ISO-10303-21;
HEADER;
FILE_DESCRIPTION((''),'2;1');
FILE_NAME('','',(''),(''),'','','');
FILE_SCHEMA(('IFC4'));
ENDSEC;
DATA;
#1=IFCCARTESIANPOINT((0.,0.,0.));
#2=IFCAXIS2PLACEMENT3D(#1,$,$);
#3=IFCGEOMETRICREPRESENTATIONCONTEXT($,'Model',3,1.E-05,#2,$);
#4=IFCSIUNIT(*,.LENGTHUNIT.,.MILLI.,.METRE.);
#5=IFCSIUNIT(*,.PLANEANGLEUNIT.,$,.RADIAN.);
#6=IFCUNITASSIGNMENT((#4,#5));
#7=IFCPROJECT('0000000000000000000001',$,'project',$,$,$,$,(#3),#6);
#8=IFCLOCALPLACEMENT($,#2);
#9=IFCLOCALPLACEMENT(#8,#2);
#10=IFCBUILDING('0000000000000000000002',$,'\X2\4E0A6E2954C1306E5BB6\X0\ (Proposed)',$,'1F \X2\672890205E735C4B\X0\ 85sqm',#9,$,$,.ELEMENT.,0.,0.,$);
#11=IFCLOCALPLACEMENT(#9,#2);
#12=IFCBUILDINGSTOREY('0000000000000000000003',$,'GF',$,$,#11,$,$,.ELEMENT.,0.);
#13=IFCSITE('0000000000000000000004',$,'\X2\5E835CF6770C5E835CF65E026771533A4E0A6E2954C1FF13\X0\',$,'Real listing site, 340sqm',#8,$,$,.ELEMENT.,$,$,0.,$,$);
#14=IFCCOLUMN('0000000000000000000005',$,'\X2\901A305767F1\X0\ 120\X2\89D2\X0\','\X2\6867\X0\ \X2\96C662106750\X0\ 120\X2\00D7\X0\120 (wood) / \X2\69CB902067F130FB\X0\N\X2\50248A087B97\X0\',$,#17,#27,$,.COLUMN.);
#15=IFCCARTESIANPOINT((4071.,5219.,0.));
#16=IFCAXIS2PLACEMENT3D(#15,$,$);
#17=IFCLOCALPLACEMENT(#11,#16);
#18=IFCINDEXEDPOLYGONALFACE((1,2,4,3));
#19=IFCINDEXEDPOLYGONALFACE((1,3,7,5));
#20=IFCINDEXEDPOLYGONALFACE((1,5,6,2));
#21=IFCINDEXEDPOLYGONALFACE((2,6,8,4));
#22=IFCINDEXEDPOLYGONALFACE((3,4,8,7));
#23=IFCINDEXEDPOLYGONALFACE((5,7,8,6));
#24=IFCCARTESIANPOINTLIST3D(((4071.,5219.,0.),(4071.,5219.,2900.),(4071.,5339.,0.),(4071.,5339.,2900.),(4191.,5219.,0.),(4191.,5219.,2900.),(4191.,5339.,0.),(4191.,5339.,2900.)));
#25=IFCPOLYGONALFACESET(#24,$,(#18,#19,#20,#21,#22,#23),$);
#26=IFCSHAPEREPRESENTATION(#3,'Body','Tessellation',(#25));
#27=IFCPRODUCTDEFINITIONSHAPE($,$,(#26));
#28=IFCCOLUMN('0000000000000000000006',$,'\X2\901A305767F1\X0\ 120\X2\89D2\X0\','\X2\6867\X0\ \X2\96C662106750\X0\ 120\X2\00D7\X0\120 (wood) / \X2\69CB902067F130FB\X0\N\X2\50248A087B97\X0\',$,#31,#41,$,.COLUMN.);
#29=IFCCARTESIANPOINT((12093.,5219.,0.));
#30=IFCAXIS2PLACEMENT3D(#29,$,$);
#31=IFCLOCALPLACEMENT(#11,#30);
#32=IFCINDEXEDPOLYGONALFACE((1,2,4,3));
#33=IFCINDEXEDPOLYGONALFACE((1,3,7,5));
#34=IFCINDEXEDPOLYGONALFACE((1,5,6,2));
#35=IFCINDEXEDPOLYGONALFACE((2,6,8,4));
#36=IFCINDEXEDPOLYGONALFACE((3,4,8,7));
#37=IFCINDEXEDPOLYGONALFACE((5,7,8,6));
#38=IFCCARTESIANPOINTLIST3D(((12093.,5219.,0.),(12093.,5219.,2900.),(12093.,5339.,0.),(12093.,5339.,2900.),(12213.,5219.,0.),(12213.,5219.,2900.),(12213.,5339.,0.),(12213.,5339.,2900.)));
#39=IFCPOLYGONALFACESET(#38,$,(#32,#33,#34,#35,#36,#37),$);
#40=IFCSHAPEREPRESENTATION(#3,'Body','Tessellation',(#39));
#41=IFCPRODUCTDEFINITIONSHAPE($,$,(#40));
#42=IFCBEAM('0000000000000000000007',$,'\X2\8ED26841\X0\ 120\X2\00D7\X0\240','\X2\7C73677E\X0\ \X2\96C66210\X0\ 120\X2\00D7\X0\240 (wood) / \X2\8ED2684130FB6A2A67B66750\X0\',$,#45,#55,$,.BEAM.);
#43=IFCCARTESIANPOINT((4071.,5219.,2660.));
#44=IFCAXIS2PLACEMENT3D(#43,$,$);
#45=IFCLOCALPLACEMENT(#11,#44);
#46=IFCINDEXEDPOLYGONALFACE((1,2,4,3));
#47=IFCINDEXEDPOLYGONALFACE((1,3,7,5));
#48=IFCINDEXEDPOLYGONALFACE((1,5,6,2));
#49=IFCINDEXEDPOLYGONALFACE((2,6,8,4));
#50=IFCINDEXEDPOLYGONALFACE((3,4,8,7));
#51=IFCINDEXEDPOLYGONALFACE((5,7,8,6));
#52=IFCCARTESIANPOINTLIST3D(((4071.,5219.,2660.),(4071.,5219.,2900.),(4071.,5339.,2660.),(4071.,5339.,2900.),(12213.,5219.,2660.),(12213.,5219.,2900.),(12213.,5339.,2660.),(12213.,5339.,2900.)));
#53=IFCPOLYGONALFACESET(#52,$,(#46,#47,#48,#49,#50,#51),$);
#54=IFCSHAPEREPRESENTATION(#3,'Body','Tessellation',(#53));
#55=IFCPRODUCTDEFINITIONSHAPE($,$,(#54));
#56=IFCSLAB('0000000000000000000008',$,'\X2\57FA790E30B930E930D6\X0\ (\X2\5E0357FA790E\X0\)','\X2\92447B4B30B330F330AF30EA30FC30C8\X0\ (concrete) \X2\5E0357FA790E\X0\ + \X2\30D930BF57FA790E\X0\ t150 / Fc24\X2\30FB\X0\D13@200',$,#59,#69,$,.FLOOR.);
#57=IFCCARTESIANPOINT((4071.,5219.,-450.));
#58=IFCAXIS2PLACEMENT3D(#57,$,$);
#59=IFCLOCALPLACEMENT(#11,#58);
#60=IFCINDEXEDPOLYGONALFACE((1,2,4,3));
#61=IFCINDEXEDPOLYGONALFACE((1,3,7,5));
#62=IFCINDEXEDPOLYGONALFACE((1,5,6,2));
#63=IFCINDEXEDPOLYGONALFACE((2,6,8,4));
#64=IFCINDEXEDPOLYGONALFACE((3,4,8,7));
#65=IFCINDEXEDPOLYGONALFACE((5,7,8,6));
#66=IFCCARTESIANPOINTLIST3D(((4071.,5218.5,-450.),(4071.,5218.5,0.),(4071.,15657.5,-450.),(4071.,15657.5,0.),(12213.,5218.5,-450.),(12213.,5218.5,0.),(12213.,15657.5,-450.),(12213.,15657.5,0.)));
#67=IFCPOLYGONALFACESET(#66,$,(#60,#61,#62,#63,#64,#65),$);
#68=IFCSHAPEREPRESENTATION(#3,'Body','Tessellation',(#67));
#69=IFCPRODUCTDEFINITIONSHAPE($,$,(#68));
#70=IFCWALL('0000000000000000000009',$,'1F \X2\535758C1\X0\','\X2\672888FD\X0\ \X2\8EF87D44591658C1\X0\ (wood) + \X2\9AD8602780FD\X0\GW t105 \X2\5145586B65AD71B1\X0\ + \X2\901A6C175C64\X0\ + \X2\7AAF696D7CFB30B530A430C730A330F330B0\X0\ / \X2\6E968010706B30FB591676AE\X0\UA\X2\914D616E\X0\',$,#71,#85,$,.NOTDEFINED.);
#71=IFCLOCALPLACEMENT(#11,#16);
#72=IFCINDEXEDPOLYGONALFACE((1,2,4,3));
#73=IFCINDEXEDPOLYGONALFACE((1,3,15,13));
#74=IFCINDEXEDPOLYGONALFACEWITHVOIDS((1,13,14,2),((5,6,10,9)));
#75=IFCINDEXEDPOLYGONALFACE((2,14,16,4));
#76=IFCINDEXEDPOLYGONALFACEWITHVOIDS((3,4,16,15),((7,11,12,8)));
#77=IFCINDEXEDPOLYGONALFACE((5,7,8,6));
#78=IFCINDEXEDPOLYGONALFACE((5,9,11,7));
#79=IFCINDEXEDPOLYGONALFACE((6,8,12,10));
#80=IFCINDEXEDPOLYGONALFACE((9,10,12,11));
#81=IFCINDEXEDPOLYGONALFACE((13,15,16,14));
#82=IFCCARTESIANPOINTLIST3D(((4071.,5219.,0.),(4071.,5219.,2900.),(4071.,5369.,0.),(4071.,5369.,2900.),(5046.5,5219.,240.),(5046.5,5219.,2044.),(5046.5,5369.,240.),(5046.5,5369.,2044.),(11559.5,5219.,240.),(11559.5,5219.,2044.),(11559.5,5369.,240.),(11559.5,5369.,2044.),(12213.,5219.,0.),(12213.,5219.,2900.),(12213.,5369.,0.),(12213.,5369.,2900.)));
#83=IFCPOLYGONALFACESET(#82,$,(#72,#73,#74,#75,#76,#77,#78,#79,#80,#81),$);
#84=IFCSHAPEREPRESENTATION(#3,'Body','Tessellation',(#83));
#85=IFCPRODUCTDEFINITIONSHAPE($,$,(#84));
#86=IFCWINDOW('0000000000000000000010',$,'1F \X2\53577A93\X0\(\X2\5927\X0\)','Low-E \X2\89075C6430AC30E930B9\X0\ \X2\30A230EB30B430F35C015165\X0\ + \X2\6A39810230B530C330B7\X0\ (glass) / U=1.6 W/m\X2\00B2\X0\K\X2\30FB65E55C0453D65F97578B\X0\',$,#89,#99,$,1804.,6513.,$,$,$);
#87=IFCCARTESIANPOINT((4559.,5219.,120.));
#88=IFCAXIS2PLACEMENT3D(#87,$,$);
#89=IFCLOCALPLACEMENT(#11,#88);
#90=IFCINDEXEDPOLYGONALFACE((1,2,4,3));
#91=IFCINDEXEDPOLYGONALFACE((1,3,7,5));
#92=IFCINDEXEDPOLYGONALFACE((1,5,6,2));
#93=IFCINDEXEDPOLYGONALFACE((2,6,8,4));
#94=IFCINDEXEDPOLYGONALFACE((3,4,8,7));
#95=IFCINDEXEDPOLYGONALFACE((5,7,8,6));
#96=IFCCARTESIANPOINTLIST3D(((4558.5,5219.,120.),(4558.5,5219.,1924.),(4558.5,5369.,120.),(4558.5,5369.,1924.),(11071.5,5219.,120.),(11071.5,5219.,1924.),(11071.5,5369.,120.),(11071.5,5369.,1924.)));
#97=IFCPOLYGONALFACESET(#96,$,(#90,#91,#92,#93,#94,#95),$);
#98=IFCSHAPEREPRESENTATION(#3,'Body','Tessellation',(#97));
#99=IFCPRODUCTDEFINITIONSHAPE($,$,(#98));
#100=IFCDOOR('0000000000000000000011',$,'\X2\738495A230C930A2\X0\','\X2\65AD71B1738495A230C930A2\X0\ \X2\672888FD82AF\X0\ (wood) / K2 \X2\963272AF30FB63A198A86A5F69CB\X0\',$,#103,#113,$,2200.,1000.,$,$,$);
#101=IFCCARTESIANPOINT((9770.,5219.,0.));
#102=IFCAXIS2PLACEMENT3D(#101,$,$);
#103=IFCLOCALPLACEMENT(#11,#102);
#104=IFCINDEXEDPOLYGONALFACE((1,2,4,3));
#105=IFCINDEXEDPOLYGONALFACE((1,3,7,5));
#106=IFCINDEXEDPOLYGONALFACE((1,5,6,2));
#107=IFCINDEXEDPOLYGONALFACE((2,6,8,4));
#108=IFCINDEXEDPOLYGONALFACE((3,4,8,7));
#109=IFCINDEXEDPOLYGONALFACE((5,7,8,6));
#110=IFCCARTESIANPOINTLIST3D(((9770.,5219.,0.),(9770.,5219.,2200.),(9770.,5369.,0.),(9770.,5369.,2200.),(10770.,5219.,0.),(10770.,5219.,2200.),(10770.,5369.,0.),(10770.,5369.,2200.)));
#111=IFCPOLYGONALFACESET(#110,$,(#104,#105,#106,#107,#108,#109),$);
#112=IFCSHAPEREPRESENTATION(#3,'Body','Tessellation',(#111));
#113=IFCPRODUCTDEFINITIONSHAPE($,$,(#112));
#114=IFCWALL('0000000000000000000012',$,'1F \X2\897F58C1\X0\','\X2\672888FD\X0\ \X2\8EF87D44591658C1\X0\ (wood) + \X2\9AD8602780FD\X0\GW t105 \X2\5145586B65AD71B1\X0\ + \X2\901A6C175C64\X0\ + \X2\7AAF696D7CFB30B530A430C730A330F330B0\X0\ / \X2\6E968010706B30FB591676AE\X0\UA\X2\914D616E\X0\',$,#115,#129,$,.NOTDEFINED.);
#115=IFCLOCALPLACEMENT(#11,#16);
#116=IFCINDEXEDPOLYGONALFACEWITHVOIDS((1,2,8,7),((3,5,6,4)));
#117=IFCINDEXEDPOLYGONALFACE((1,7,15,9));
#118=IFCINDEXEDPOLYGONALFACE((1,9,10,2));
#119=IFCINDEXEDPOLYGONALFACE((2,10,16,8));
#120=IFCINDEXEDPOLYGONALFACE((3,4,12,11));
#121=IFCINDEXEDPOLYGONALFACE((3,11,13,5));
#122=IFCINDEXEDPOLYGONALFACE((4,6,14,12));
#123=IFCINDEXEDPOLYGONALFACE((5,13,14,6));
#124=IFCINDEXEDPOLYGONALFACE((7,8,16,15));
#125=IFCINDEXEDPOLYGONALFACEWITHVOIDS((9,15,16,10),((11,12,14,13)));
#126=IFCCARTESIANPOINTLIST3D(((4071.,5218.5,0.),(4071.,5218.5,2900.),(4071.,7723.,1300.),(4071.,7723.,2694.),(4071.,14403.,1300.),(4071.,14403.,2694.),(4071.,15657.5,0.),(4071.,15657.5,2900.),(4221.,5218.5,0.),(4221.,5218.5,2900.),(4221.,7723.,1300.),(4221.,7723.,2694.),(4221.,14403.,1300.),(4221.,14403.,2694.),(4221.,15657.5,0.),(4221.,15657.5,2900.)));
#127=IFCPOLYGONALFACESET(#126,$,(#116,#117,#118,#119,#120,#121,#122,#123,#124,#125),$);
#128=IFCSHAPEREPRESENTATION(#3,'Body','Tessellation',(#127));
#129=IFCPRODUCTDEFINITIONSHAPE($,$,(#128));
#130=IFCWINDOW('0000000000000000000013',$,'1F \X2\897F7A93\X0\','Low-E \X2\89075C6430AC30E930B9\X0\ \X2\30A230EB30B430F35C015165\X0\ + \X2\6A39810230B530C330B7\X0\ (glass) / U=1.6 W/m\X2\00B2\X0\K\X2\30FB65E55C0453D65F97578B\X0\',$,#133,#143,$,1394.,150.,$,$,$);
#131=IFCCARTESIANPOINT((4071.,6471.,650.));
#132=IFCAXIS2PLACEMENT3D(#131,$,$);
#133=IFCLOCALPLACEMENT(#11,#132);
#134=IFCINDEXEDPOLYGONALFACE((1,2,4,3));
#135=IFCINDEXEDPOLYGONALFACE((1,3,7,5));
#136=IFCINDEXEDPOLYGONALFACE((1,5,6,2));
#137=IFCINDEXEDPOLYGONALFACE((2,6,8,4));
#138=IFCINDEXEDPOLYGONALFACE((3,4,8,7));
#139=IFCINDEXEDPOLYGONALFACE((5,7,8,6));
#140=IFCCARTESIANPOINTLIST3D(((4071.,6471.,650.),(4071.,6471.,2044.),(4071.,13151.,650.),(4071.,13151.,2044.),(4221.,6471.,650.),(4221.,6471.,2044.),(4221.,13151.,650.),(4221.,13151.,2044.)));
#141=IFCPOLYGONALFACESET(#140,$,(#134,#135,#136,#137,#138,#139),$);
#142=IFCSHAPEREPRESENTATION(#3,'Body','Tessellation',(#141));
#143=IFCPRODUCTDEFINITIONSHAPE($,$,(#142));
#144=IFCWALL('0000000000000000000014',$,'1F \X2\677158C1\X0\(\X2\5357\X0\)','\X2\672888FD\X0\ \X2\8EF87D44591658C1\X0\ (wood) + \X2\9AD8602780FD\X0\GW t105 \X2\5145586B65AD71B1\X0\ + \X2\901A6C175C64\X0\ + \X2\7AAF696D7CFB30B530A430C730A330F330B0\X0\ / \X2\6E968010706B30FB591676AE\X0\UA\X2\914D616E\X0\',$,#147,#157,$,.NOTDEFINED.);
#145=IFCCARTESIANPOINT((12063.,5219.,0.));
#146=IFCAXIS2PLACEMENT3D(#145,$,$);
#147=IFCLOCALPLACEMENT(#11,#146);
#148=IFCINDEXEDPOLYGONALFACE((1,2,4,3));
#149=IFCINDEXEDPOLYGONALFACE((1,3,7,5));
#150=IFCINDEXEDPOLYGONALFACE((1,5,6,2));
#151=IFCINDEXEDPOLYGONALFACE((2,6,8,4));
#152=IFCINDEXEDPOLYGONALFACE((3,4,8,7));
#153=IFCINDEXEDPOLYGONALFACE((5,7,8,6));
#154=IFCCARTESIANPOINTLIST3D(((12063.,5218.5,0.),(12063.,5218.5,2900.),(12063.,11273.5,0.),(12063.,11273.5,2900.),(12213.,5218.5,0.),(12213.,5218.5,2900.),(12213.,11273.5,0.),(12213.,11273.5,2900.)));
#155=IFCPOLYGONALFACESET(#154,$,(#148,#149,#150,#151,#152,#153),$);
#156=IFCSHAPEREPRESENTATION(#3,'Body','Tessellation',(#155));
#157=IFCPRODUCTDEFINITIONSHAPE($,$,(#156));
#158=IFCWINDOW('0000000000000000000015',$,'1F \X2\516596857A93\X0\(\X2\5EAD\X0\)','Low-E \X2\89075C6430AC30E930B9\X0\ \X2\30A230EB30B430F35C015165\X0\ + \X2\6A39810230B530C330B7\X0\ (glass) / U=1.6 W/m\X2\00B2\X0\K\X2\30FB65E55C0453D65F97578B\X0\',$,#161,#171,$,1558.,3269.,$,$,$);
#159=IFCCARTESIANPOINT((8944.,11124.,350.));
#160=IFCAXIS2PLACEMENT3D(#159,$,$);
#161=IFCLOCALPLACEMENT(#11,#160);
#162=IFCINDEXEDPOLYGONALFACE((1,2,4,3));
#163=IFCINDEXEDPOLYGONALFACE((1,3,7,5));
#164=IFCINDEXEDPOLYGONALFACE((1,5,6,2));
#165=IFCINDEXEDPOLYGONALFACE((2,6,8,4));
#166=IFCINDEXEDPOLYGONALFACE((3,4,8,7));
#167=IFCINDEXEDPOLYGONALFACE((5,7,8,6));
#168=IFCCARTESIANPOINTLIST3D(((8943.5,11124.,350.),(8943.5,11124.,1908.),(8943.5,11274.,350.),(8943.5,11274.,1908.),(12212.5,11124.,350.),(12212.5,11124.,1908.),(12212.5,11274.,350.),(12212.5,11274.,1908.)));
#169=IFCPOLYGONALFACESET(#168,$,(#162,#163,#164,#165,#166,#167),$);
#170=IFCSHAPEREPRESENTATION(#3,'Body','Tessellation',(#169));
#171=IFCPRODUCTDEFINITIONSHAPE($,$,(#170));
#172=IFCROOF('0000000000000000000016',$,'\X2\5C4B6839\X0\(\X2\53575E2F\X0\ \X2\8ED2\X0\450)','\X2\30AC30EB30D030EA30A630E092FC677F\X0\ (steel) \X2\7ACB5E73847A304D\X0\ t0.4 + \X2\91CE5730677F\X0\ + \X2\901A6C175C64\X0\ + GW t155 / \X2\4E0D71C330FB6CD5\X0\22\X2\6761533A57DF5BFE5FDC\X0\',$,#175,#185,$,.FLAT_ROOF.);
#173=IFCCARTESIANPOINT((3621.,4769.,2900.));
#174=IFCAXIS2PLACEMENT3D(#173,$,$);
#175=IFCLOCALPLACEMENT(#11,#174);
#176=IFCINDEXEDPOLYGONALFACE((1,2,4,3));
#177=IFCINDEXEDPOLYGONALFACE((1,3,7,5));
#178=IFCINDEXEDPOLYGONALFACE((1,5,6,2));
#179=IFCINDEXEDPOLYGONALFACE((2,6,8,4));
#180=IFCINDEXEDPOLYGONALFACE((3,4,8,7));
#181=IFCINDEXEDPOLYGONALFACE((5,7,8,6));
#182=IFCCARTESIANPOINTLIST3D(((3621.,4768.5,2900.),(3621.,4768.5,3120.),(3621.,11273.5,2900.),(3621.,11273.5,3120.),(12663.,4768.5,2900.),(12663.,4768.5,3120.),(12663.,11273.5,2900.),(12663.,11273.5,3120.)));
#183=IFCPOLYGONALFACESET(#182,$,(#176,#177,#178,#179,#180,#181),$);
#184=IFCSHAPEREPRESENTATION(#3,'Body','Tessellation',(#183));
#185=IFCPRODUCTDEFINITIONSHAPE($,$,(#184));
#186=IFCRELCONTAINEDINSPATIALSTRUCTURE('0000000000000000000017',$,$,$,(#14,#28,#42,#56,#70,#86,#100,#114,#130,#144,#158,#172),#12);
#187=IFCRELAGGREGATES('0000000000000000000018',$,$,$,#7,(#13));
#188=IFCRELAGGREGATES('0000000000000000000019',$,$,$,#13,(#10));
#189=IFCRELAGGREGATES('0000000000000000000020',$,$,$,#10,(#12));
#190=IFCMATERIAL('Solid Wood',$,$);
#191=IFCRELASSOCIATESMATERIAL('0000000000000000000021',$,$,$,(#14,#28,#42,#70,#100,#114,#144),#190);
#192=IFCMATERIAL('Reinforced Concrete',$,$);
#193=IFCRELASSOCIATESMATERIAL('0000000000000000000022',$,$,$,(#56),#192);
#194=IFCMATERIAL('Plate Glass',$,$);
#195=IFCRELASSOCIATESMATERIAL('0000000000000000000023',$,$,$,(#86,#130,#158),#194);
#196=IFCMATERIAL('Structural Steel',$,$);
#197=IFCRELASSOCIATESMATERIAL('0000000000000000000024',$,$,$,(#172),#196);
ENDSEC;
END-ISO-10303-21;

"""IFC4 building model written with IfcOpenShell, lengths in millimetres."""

from ifc_helpers import new_model, si_unit, frame, frame_2d, origin, place, context, project, spatial, rectangle, extrude, material, element, fill, save


model = new_model("IFC4")

# Units and contexts
model_context = context("Model", 3, precision=1e-05, world=origin())
ifc_project = project(units=[si_unit("LENGTHUNIT", "METRE", prefix="MILLI"), si_unit("PLANEANGLEUNIT", "RADIAN")], contexts=[model_context])

# Site, building, storey
site_placement = place(None, origin())
site = spatial("IfcSite", under=ifc_project, at=site_placement, Name="広島県広島市東区上温品３", ObjectType="Real listing site, 340sqm", CompositionType="ELEMENT", RefElevation=0.0)
building_placement = place(site_placement, origin())
building = spatial("IfcBuilding", under=site, at=building_placement, Name="上温品の家 (Proposed)", ObjectType="1F 木造平屋 85sqm", CompositionType="ELEMENT", ElevationOfRefHeight=0.0, ElevationOfTerrain=0.0)
storey_placement = place(building_placement, origin())
storey = spatial("IfcBuildingStorey", under=building, at=storey_placement, Name="GF", CompositionType="ELEMENT", Elevation=0.0)

# Columns
ifc_material_1 = material(Name="Solid Wood")
column_1_placement = place(storey_placement, frame((4071.0, 5219.0, 0.0)))
element("IfcColumn", 1, at=column_1_placement, inside=storey, material=ifc_material_1, Name="通し柱 120角", Description="桧 集成材 120×120 (wood) / 構造柱・N値計算", PredefinedType="COLUMN", context=model_context, shape_type="SweptSolid", body=[
    extrude(rectangle(XDim=120.0, YDim=120.0, at=frame_2d((60.0, 60.0))), frame((4071.0, 5219.0, 0.0)), (0.0, 0.0, 1.0), 2900.0),
])
column_2_placement = place(storey_placement, frame((12093.0, 5219.0, 0.0)))
element("IfcColumn", 2, at=column_2_placement, inside=storey, material=ifc_material_1, Name="通し柱 120角", Description="桧 集成材 120×120 (wood) / 構造柱・N値計算", PredefinedType="COLUMN", context=model_context, shape_type="SweptSolid", body=[
    extrude(rectangle(XDim=120.0, YDim=120.0, at=frame_2d((60.0, 60.0))), frame((12093.0, 5219.0, 0.0)), (0.0, 0.0, 1.0), 2900.0),
])

# Beam
beam_1_placement = place(storey_placement, frame((4071.0, 5219.0, 2660.0)))
element("IfcBeam", 3, at=beam_1_placement, inside=storey, material=ifc_material_1, Name="軒桁 120×240", Description="米松 集成 120×240 (wood) / 軒桁・横架材", PredefinedType="BEAM", context=model_context, shape_type="SweptSolid", body=[
    extrude(rectangle(XDim=8142.0, YDim=120.0, at=frame_2d((4071.0, 60.0))), frame((4071.0, 5219.0, 2660.0)), (0.0, 0.0, 1.0), 240.0),
])

# Slab
ifc_material_2 = material(Name="Reinforced Concrete")
slab_1_placement = place(storey_placement, frame((4071.0, 5219.0, -450.0)))
element("IfcSlab", 4, at=slab_1_placement, inside=storey, material=ifc_material_2, Name="基礎スラブ (布基礎)", Description="鉄筋コンクリート (concrete) 布基礎 + ベタ基礎 t150 / Fc24・D13@200", PredefinedType="FLOOR", context=model_context, shape_type="SweptSolid", body=[
    extrude(rectangle(XDim=8142.0, YDim=10439.0, at=frame_2d((4071.0, 5219.0))), frame((4071.0, 5219.0, -450.0)), (0.0, 0.0, 1.0), 450.0),
])

# Wall, openings, window, door
wall_1_placement = place(storey_placement, frame((4071.0, 5219.0, 0.0)))
wall_1 = element("IfcWall", 5, at=wall_1_placement, inside=storey, material=ifc_material_1, Name="1F 南壁", Description="木製 軸組外壁 (wood) + 高性能GW t105 充填断熱 + 通気層 + 窯業系サイディング / 準耐火・外皮UA配慮", PredefinedType="NOTDEFINED", context=model_context, shape_type="SweptSolid", body=[
    extrude(rectangle(XDim=8142.0, YDim=150.0, at=frame_2d((4071.0, 75.0))), frame((4071.0, 5219.0, 0.0)), (0.0, 0.0, 1.0), 2900.0),
])
opening_1_placement = place(storey_placement, frame((4559.0, 5219.0, 120.0)))
opening_1 = element("IfcOpeningElement", 6, at=opening_1_placement, cuts=wall_1, PredefinedType="NOTDEFINED", context=model_context, shape_type="SweptSolid", body=[
    extrude(rectangle(XDim=6513.0, YDim=150.0, at=frame_2d((3256.0, 75.0))), frame((4559.0, 5219.0, 120.0)), (0.0, 0.0, 1.0), 1804.0),
])
opening_2_placement = place(storey_placement, frame((9770.0, 5219.0, 0.0)))
opening_2 = element("IfcOpeningElement", 7, at=opening_2_placement, cuts=wall_1, PredefinedType="NOTDEFINED", context=model_context, shape_type="SweptSolid", body=[
    extrude(rectangle(XDim=1000.0, YDim=150.0, at=frame_2d((500.0, 75.0))), frame((9770.0, 5219.0, 0.0)), (0.0, 0.0, 1.0), 2200.0),
])
ifc_material_3 = material(Name="Plate Glass")
window_1_placement = place(storey_placement, frame((4559.0, 5219.0, 120.0)))
window_1 = element("IfcWindow", 8, at=window_1_placement, inside=storey, material=ifc_material_3, Name="1F 南窓(大)", Description="Low-E 複層ガラス アルゴン封入 + 樹脂サッシ (glass) / U=1.6 W/m²K・日射取得型", OverallHeight=1804.0, OverallWidth=6513.0, context=model_context, shape_type="SweptSolid", body=[
    extrude(rectangle(XDim=6513.0, YDim=150.0, at=frame_2d((3256.0, 75.0))), frame((4559.0, 5219.0, 120.0)), (0.0, 0.0, 1.0), 1804.0),
])
fill(opening_1, window_1)
door_1_placement = place(storey_placement, frame((9770.0, 5219.0, 0.0)))
door_1 = element("IfcDoor", 9, at=door_1_placement, inside=storey, material=ifc_material_1, Name="玄関ドア", Description="断熱玄関ドア 木製芯 (wood) / K2 防犯・採風機構", OverallHeight=2200.0, OverallWidth=1000.0, context=model_context, shape_type="SweptSolid", body=[
    extrude(rectangle(XDim=1000.0, YDim=150.0, at=frame_2d((500.0, 75.0))), frame((9770.0, 5219.0, 0.0)), (0.0, 0.0, 1.0), 2200.0),
])
fill(opening_2, door_1)

# Walls, openings, windows
wall_2_placement = place(storey_placement, frame((4071.0, 5219.0, 0.0)))
wall_2 = element("IfcWall", 10, at=wall_2_placement, inside=storey, material=ifc_material_1, Name="1F 西壁", Description="木製 軸組外壁 (wood) + 高性能GW t105 充填断熱 + 通気層 + 窯業系サイディング / 準耐火・外皮UA配慮", PredefinedType="NOTDEFINED", context=model_context, shape_type="SweptSolid", body=[
    extrude(rectangle(XDim=150.0, YDim=10439.0, at=frame_2d((75.0, 5219.0))), frame((4071.0, 5219.0, 0.0)), (0.0, 0.0, 1.0), 2900.0),
])
opening_3_placement = place(storey_placement, frame((4071.0, 6471.0, 650.0)))
opening_3 = element("IfcOpeningElement", 11, at=opening_3_placement, cuts=wall_2, PredefinedType="NOTDEFINED", context=model_context, shape_type="SweptSolid", body=[
    extrude(rectangle(XDim=150.0, YDim=6680.0, at=frame_2d((75.0, 3340.0))), frame((4071.0, 6471.0, 650.0)), (0.0, 0.0, 1.0), 1394.0),
])
window_2_placement = place(storey_placement, frame((4071.0, 6471.0, 650.0)))
window_2 = element("IfcWindow", 12, at=window_2_placement, inside=storey, material=ifc_material_3, Name="1F 西窓", Description="Low-E 複層ガラス アルゴン封入 + 樹脂サッシ (glass) / U=1.6 W/m²K・日射取得型", OverallHeight=1394.0, OverallWidth=150.0, context=model_context, shape_type="SweptSolid", body=[
    extrude(rectangle(XDim=150.0, YDim=6680.0, at=frame_2d((75.0, 3340.0))), frame((4071.0, 6471.0, 650.0)), (0.0, 0.0, 1.0), 1394.0),
])
fill(opening_3, window_2)
wall_3_placement = place(storey_placement, frame((12063.0, 5219.0, 0.0)))
wall_3 = element("IfcWall", 13, at=wall_3_placement, inside=storey, material=ifc_material_1, Name="1F 東壁(南)", Description="木製 軸組外壁 (wood) + 高性能GW t105 充填断熱 + 通気層 + 窯業系サイディング / 準耐火・外皮UA配慮", PredefinedType="NOTDEFINED", context=model_context, shape_type="SweptSolid", body=[
    extrude(rectangle(XDim=150.0, YDim=6055.0, at=frame_2d((75.0, 3027.0))), frame((12063.0, 5219.0, 0.0)), (0.0, 0.0, 1.0), 2900.0),
])
opening_4_placement = place(storey_placement, frame((8944.0, 11124.0, 350.0)))
opening_4 = element("IfcOpeningElement", 14, at=opening_4_placement, cuts=wall_3, PredefinedType="NOTDEFINED", context=model_context, shape_type="SweptSolid", body=[
    extrude(rectangle(XDim=3269.0, YDim=150.0, at=frame_2d((1634.0, 75.0))), frame((8944.0, 11124.0, 350.0)), (0.0, 0.0, 1.0), 1558.0),
])
window_3_placement = place(storey_placement, frame((8944.0, 11124.0, 350.0)))
window_3 = element("IfcWindow", 15, at=window_3_placement, inside=storey, material=ifc_material_3, Name="1F 入隅窓(庭)", Description="Low-E 複層ガラス アルゴン封入 + 樹脂サッシ (glass) / U=1.6 W/m²K・日射取得型", OverallHeight=1558.0, OverallWidth=3269.0, context=model_context, shape_type="SweptSolid", body=[
    extrude(rectangle(XDim=3269.0, YDim=150.0, at=frame_2d((1634.0, 75.0))), frame((8944.0, 11124.0, 350.0)), (0.0, 0.0, 1.0), 1558.0),
])
fill(opening_4, window_3)

# Roof
ifc_material_4 = material(Name="Structural Steel")
roof_placement = place(storey_placement, frame((3621.0, 4769.0, 2900.0)))
element("IfcRoof", 16, at=roof_placement, inside=storey, material=ifc_material_4, Name="屋根(南帯 軒450)", Description="ガルバリウム鋼板 (steel) 立平葺き t0.4 + 野地板 + 通気層 + GW t155 / 不燃・法22条区域対応", PredefinedType="FLAT_ROOF", context=model_context, shape_type="SweptSolid", body=[
    extrude(rectangle(XDim=9042.0, YDim=6505.0, at=frame_2d((4521.0, 3252.0))), frame((3621.0, 4769.0, 2900.0)), (0.0, 0.0, 1.0), 220.0),
])

save(model, "model.ifc")
